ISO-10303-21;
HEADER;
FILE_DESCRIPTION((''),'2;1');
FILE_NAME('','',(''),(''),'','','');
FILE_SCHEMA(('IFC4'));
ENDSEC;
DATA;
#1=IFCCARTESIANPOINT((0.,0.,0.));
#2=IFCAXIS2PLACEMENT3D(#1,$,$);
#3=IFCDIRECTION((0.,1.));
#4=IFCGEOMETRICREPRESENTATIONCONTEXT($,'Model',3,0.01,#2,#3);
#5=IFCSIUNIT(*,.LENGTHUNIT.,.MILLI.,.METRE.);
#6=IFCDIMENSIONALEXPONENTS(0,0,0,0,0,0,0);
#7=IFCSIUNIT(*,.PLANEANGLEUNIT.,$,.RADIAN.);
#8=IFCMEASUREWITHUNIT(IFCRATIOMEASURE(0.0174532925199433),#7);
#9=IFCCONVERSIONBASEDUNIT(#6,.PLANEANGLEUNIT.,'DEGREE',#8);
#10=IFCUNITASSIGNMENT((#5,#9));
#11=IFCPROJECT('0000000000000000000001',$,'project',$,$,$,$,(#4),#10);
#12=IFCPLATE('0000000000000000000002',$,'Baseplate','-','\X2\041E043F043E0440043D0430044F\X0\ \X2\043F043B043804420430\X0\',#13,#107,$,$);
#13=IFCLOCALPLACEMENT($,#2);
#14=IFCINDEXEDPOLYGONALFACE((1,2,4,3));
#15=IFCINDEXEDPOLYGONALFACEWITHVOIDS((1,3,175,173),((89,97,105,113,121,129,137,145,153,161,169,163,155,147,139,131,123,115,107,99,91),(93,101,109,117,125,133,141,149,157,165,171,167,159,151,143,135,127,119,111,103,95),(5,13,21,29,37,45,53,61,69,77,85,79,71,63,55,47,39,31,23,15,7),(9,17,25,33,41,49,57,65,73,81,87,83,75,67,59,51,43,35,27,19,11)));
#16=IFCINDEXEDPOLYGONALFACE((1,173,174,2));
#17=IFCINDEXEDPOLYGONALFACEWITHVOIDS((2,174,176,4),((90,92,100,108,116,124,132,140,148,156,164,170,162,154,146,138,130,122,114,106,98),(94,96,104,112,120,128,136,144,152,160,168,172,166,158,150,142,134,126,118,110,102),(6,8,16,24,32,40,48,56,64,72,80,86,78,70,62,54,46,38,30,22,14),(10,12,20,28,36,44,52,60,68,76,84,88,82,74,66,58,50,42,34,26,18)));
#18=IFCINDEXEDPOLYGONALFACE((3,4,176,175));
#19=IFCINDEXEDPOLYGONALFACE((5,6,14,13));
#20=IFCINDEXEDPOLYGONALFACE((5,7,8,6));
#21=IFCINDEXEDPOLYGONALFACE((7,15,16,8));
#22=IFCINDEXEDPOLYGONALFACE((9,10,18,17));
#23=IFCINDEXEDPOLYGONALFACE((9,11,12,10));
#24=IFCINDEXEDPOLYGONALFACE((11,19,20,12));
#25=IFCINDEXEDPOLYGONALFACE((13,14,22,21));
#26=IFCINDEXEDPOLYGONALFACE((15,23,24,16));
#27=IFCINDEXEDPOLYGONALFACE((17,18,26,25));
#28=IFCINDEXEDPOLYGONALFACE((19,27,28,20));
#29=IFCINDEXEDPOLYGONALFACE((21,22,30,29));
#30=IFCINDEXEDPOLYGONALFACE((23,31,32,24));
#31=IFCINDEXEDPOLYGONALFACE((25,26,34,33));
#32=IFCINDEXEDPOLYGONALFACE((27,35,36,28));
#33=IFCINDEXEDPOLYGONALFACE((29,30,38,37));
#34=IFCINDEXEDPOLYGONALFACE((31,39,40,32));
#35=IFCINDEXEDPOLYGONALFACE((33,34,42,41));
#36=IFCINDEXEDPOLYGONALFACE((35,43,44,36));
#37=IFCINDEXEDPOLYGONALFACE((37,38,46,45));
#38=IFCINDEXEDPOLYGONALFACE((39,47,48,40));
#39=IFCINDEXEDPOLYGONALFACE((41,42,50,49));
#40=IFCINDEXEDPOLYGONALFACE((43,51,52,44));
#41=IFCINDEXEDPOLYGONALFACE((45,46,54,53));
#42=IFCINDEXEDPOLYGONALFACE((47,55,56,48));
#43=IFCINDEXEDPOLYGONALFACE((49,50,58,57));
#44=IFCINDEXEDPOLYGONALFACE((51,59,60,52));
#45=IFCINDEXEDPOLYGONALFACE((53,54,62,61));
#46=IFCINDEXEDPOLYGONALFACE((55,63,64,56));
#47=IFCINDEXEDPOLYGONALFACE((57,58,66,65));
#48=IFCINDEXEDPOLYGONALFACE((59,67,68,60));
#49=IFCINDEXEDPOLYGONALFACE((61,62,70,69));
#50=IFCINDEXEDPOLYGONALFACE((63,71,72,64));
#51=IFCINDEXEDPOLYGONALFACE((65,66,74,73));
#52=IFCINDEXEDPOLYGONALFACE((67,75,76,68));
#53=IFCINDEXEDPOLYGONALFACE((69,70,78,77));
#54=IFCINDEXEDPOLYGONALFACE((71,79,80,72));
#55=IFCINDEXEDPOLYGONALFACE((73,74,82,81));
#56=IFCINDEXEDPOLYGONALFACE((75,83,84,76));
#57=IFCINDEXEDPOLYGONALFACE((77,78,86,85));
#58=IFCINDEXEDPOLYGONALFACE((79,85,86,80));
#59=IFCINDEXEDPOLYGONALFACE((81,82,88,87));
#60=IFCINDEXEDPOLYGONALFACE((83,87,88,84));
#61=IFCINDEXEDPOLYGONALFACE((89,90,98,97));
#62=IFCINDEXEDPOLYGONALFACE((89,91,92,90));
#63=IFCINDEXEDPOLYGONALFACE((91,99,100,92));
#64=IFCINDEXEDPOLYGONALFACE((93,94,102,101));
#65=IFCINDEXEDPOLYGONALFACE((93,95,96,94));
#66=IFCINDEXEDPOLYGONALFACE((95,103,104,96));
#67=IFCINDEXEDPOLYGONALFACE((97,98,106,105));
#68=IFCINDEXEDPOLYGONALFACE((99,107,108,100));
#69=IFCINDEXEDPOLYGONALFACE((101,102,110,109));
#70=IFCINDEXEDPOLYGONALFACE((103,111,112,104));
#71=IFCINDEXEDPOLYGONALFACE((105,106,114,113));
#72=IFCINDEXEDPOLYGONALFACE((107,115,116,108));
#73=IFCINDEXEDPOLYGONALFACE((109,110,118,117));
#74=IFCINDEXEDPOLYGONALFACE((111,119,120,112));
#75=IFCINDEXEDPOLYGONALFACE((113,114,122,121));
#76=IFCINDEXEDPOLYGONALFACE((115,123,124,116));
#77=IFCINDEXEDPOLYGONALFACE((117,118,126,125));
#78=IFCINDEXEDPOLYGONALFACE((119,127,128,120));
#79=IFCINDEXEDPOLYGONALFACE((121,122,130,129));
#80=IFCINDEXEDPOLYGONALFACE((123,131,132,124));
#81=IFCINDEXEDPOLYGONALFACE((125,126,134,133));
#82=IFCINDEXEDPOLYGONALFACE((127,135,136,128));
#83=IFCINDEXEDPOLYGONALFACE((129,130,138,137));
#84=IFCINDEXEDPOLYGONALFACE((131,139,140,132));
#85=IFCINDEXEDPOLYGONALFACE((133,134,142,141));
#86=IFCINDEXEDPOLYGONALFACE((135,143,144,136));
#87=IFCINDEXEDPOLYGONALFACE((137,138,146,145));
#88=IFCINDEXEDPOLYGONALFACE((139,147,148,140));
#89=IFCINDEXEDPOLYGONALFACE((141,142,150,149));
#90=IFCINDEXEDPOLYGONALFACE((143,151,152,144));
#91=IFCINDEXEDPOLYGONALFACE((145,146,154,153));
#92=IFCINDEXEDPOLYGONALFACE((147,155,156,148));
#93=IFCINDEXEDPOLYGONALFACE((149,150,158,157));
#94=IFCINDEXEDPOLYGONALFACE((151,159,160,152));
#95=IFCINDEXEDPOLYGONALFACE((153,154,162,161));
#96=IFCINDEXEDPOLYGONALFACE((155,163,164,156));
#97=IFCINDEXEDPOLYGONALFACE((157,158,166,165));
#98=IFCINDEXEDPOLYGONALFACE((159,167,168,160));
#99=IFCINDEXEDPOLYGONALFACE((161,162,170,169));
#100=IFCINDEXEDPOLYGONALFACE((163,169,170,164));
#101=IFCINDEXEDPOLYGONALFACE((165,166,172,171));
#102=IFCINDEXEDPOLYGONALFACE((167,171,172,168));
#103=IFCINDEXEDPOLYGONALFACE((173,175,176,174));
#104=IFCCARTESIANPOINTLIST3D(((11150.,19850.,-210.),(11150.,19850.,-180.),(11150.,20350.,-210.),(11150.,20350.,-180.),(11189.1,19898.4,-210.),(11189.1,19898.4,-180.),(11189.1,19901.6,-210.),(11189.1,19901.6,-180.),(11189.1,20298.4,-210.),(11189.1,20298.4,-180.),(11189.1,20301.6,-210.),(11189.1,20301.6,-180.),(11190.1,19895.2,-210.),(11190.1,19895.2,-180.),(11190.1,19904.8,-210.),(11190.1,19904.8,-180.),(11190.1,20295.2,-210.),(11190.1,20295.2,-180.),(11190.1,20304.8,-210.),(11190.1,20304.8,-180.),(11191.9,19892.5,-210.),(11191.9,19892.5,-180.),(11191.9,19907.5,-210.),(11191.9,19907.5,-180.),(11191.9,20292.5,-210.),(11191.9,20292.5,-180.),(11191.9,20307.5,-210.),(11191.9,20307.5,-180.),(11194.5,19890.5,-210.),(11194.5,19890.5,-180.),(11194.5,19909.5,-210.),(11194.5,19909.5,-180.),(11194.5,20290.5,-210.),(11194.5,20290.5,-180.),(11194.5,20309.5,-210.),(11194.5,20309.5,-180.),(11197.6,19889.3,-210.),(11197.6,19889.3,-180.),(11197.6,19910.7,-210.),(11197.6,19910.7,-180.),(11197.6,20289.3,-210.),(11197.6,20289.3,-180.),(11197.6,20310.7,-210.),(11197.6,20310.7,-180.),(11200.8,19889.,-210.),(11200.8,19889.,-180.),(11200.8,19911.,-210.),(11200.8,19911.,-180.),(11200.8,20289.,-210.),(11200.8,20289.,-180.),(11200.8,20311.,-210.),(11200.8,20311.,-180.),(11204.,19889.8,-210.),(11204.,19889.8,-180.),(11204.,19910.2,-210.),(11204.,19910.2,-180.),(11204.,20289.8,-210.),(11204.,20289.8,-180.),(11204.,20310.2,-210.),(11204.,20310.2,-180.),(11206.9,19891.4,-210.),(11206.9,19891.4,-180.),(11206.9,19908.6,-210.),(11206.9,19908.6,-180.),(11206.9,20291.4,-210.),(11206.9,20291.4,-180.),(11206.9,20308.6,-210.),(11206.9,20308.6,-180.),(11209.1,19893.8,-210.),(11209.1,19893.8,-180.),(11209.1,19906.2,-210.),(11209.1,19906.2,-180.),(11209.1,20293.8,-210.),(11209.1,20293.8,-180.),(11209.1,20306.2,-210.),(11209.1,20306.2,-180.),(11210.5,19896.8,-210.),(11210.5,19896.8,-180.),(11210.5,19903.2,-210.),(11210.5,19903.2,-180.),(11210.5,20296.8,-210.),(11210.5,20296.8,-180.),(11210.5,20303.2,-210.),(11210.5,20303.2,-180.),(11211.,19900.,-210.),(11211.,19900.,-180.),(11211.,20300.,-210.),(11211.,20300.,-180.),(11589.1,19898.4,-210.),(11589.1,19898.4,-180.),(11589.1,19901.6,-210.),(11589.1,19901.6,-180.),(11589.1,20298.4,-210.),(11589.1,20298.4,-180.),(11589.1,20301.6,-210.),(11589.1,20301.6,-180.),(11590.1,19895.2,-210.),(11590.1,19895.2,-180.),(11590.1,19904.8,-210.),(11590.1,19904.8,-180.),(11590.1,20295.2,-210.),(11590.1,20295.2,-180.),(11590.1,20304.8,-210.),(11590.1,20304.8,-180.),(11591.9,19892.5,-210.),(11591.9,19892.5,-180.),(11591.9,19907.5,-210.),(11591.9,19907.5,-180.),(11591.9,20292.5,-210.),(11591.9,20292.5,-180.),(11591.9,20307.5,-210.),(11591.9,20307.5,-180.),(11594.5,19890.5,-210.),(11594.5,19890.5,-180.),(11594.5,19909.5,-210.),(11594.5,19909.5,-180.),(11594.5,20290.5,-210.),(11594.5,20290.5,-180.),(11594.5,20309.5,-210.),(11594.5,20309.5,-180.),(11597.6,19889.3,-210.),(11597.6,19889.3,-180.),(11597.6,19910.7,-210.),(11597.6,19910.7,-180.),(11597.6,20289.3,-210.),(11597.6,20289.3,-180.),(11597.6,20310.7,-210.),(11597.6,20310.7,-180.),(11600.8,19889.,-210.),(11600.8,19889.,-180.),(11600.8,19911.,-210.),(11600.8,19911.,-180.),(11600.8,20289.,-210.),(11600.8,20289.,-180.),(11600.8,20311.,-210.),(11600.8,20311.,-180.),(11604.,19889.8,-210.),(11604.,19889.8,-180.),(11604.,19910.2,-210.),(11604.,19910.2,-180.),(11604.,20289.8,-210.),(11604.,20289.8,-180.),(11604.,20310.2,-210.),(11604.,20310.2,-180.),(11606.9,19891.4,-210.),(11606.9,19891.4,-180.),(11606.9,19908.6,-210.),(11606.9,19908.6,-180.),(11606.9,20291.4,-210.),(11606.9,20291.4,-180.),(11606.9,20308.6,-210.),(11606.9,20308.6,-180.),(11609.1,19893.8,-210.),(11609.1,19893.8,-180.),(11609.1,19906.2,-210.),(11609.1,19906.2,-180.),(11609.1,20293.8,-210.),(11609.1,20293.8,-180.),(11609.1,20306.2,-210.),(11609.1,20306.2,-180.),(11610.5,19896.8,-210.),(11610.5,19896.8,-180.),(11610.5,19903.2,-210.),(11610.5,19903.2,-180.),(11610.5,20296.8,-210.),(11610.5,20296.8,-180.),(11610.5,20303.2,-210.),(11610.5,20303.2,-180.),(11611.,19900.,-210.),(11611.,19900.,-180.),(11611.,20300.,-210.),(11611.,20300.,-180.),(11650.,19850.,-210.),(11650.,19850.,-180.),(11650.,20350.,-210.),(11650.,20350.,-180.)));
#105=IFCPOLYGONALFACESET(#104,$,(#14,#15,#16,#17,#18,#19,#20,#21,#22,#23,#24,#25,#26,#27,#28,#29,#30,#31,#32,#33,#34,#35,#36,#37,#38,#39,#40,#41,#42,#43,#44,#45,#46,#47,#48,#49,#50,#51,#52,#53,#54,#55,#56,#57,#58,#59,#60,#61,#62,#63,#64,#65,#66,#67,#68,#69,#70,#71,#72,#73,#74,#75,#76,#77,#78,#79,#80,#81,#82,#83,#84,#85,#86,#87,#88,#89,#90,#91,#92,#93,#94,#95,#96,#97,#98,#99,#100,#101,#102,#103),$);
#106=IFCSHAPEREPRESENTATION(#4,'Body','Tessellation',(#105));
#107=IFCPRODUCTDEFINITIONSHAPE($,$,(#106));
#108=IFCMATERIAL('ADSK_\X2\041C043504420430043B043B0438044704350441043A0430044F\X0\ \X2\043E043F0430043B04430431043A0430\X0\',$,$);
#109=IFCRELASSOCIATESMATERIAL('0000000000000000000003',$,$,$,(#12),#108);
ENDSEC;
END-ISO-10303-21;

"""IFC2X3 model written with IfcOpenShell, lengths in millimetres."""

from ifc_helpers import new_model, entity, si_unit, converted_unit, direction, frame, frame_2d, origin, origin_with_axes, place, context, project, polyline, circle, outline, extrude, material, element, save


model = new_model("IFC2X3")

# Units and contexts
model_context = context("Model", 3, precision=0.01, world=origin(), true_north=direction((0.0, 1.0)))
ifc_project = project(units=[si_unit("LENGTHUNIT", "METRE", prefix="MILLI"), converted_unit("PLANEANGLEUNIT", "DEGREE", entity("IfcRatioMeasure", 0.0174532925199433), si_unit("PLANEANGLEUNIT", "RADIAN"), dimensions=[0, 0, 0, 0, 0, 0, 0])], contexts=[model_context])

# Plate, openings
ifc_material = material(Name="ADSK_Металлическая опалубка")
plate_placement = place(None, frame((11150.0, 20350.0, -180.0), z_axis=(0.0, 0.0, -1.0), x_axis=(1.0, 0.0, 0.0)))
plate = element("IfcPlate", 1, at=plate_placement, material=ifc_material, Name="Baseplate", Description="-", ObjectType="Опорная плита", context=model_context, shape_type="SweptSolid", body=[
    extrude(outline(polyline([(0.0, 0.0), (500.0, 0.0), (500.0, 500.0), (0.0, 500.0), (0.0, 0.0)])), origin_with_axes(), (0.0, 0.0, 1.0), 30.0),
])
placement = place(plate_placement, frame((250.0, 250.0, 30.5), z_axis=(0.0, 0.0, -1.0), x_axis=(1.0, 0.0, 0.0)))
element("IfcOpeningElement", 2, at=placement, cuts=plate, ObjectType="Opening", context=model_context, shape_type="SweptSolid", body=[
    extrude(circle(Radius=11.0, at=frame_2d((200.0, 200.0), x_axis=(1.0, 0.0))), origin(), (0.0, 0.0, 1.0), 31.0),
])
element("IfcOpeningElement", 3, at=placement, cuts=plate, ObjectType="Opening", context=model_context, shape_type="SweptSolid", body=[
    extrude(circle(Radius=11.0, at=frame_2d((-200.0, 200.0), x_axis=(1.0, 0.0))), origin(), (0.0, 0.0, 1.0), 31.0),
])
element("IfcOpeningElement", 4, at=placement, cuts=plate, ObjectType="Opening", context=model_context, shape_type="SweptSolid", body=[
    extrude(circle(Radius=11.0, at=frame_2d((200.0, -200.0), x_axis=(1.0, 0.0))), origin(), (0.0, 0.0, 1.0), 31.0),
])
element("IfcOpeningElement", 5, at=placement, cuts=plate, ObjectType="Opening", context=model_context, shape_type="SweptSolid", body=[
    extrude(circle(Radius=11.0, at=frame_2d((-200.0, -200.0), x_axis=(1.0, 0.0))), origin(), (0.0, 0.0, 1.0), 31.0),
])

save(model, "model.ifc")
